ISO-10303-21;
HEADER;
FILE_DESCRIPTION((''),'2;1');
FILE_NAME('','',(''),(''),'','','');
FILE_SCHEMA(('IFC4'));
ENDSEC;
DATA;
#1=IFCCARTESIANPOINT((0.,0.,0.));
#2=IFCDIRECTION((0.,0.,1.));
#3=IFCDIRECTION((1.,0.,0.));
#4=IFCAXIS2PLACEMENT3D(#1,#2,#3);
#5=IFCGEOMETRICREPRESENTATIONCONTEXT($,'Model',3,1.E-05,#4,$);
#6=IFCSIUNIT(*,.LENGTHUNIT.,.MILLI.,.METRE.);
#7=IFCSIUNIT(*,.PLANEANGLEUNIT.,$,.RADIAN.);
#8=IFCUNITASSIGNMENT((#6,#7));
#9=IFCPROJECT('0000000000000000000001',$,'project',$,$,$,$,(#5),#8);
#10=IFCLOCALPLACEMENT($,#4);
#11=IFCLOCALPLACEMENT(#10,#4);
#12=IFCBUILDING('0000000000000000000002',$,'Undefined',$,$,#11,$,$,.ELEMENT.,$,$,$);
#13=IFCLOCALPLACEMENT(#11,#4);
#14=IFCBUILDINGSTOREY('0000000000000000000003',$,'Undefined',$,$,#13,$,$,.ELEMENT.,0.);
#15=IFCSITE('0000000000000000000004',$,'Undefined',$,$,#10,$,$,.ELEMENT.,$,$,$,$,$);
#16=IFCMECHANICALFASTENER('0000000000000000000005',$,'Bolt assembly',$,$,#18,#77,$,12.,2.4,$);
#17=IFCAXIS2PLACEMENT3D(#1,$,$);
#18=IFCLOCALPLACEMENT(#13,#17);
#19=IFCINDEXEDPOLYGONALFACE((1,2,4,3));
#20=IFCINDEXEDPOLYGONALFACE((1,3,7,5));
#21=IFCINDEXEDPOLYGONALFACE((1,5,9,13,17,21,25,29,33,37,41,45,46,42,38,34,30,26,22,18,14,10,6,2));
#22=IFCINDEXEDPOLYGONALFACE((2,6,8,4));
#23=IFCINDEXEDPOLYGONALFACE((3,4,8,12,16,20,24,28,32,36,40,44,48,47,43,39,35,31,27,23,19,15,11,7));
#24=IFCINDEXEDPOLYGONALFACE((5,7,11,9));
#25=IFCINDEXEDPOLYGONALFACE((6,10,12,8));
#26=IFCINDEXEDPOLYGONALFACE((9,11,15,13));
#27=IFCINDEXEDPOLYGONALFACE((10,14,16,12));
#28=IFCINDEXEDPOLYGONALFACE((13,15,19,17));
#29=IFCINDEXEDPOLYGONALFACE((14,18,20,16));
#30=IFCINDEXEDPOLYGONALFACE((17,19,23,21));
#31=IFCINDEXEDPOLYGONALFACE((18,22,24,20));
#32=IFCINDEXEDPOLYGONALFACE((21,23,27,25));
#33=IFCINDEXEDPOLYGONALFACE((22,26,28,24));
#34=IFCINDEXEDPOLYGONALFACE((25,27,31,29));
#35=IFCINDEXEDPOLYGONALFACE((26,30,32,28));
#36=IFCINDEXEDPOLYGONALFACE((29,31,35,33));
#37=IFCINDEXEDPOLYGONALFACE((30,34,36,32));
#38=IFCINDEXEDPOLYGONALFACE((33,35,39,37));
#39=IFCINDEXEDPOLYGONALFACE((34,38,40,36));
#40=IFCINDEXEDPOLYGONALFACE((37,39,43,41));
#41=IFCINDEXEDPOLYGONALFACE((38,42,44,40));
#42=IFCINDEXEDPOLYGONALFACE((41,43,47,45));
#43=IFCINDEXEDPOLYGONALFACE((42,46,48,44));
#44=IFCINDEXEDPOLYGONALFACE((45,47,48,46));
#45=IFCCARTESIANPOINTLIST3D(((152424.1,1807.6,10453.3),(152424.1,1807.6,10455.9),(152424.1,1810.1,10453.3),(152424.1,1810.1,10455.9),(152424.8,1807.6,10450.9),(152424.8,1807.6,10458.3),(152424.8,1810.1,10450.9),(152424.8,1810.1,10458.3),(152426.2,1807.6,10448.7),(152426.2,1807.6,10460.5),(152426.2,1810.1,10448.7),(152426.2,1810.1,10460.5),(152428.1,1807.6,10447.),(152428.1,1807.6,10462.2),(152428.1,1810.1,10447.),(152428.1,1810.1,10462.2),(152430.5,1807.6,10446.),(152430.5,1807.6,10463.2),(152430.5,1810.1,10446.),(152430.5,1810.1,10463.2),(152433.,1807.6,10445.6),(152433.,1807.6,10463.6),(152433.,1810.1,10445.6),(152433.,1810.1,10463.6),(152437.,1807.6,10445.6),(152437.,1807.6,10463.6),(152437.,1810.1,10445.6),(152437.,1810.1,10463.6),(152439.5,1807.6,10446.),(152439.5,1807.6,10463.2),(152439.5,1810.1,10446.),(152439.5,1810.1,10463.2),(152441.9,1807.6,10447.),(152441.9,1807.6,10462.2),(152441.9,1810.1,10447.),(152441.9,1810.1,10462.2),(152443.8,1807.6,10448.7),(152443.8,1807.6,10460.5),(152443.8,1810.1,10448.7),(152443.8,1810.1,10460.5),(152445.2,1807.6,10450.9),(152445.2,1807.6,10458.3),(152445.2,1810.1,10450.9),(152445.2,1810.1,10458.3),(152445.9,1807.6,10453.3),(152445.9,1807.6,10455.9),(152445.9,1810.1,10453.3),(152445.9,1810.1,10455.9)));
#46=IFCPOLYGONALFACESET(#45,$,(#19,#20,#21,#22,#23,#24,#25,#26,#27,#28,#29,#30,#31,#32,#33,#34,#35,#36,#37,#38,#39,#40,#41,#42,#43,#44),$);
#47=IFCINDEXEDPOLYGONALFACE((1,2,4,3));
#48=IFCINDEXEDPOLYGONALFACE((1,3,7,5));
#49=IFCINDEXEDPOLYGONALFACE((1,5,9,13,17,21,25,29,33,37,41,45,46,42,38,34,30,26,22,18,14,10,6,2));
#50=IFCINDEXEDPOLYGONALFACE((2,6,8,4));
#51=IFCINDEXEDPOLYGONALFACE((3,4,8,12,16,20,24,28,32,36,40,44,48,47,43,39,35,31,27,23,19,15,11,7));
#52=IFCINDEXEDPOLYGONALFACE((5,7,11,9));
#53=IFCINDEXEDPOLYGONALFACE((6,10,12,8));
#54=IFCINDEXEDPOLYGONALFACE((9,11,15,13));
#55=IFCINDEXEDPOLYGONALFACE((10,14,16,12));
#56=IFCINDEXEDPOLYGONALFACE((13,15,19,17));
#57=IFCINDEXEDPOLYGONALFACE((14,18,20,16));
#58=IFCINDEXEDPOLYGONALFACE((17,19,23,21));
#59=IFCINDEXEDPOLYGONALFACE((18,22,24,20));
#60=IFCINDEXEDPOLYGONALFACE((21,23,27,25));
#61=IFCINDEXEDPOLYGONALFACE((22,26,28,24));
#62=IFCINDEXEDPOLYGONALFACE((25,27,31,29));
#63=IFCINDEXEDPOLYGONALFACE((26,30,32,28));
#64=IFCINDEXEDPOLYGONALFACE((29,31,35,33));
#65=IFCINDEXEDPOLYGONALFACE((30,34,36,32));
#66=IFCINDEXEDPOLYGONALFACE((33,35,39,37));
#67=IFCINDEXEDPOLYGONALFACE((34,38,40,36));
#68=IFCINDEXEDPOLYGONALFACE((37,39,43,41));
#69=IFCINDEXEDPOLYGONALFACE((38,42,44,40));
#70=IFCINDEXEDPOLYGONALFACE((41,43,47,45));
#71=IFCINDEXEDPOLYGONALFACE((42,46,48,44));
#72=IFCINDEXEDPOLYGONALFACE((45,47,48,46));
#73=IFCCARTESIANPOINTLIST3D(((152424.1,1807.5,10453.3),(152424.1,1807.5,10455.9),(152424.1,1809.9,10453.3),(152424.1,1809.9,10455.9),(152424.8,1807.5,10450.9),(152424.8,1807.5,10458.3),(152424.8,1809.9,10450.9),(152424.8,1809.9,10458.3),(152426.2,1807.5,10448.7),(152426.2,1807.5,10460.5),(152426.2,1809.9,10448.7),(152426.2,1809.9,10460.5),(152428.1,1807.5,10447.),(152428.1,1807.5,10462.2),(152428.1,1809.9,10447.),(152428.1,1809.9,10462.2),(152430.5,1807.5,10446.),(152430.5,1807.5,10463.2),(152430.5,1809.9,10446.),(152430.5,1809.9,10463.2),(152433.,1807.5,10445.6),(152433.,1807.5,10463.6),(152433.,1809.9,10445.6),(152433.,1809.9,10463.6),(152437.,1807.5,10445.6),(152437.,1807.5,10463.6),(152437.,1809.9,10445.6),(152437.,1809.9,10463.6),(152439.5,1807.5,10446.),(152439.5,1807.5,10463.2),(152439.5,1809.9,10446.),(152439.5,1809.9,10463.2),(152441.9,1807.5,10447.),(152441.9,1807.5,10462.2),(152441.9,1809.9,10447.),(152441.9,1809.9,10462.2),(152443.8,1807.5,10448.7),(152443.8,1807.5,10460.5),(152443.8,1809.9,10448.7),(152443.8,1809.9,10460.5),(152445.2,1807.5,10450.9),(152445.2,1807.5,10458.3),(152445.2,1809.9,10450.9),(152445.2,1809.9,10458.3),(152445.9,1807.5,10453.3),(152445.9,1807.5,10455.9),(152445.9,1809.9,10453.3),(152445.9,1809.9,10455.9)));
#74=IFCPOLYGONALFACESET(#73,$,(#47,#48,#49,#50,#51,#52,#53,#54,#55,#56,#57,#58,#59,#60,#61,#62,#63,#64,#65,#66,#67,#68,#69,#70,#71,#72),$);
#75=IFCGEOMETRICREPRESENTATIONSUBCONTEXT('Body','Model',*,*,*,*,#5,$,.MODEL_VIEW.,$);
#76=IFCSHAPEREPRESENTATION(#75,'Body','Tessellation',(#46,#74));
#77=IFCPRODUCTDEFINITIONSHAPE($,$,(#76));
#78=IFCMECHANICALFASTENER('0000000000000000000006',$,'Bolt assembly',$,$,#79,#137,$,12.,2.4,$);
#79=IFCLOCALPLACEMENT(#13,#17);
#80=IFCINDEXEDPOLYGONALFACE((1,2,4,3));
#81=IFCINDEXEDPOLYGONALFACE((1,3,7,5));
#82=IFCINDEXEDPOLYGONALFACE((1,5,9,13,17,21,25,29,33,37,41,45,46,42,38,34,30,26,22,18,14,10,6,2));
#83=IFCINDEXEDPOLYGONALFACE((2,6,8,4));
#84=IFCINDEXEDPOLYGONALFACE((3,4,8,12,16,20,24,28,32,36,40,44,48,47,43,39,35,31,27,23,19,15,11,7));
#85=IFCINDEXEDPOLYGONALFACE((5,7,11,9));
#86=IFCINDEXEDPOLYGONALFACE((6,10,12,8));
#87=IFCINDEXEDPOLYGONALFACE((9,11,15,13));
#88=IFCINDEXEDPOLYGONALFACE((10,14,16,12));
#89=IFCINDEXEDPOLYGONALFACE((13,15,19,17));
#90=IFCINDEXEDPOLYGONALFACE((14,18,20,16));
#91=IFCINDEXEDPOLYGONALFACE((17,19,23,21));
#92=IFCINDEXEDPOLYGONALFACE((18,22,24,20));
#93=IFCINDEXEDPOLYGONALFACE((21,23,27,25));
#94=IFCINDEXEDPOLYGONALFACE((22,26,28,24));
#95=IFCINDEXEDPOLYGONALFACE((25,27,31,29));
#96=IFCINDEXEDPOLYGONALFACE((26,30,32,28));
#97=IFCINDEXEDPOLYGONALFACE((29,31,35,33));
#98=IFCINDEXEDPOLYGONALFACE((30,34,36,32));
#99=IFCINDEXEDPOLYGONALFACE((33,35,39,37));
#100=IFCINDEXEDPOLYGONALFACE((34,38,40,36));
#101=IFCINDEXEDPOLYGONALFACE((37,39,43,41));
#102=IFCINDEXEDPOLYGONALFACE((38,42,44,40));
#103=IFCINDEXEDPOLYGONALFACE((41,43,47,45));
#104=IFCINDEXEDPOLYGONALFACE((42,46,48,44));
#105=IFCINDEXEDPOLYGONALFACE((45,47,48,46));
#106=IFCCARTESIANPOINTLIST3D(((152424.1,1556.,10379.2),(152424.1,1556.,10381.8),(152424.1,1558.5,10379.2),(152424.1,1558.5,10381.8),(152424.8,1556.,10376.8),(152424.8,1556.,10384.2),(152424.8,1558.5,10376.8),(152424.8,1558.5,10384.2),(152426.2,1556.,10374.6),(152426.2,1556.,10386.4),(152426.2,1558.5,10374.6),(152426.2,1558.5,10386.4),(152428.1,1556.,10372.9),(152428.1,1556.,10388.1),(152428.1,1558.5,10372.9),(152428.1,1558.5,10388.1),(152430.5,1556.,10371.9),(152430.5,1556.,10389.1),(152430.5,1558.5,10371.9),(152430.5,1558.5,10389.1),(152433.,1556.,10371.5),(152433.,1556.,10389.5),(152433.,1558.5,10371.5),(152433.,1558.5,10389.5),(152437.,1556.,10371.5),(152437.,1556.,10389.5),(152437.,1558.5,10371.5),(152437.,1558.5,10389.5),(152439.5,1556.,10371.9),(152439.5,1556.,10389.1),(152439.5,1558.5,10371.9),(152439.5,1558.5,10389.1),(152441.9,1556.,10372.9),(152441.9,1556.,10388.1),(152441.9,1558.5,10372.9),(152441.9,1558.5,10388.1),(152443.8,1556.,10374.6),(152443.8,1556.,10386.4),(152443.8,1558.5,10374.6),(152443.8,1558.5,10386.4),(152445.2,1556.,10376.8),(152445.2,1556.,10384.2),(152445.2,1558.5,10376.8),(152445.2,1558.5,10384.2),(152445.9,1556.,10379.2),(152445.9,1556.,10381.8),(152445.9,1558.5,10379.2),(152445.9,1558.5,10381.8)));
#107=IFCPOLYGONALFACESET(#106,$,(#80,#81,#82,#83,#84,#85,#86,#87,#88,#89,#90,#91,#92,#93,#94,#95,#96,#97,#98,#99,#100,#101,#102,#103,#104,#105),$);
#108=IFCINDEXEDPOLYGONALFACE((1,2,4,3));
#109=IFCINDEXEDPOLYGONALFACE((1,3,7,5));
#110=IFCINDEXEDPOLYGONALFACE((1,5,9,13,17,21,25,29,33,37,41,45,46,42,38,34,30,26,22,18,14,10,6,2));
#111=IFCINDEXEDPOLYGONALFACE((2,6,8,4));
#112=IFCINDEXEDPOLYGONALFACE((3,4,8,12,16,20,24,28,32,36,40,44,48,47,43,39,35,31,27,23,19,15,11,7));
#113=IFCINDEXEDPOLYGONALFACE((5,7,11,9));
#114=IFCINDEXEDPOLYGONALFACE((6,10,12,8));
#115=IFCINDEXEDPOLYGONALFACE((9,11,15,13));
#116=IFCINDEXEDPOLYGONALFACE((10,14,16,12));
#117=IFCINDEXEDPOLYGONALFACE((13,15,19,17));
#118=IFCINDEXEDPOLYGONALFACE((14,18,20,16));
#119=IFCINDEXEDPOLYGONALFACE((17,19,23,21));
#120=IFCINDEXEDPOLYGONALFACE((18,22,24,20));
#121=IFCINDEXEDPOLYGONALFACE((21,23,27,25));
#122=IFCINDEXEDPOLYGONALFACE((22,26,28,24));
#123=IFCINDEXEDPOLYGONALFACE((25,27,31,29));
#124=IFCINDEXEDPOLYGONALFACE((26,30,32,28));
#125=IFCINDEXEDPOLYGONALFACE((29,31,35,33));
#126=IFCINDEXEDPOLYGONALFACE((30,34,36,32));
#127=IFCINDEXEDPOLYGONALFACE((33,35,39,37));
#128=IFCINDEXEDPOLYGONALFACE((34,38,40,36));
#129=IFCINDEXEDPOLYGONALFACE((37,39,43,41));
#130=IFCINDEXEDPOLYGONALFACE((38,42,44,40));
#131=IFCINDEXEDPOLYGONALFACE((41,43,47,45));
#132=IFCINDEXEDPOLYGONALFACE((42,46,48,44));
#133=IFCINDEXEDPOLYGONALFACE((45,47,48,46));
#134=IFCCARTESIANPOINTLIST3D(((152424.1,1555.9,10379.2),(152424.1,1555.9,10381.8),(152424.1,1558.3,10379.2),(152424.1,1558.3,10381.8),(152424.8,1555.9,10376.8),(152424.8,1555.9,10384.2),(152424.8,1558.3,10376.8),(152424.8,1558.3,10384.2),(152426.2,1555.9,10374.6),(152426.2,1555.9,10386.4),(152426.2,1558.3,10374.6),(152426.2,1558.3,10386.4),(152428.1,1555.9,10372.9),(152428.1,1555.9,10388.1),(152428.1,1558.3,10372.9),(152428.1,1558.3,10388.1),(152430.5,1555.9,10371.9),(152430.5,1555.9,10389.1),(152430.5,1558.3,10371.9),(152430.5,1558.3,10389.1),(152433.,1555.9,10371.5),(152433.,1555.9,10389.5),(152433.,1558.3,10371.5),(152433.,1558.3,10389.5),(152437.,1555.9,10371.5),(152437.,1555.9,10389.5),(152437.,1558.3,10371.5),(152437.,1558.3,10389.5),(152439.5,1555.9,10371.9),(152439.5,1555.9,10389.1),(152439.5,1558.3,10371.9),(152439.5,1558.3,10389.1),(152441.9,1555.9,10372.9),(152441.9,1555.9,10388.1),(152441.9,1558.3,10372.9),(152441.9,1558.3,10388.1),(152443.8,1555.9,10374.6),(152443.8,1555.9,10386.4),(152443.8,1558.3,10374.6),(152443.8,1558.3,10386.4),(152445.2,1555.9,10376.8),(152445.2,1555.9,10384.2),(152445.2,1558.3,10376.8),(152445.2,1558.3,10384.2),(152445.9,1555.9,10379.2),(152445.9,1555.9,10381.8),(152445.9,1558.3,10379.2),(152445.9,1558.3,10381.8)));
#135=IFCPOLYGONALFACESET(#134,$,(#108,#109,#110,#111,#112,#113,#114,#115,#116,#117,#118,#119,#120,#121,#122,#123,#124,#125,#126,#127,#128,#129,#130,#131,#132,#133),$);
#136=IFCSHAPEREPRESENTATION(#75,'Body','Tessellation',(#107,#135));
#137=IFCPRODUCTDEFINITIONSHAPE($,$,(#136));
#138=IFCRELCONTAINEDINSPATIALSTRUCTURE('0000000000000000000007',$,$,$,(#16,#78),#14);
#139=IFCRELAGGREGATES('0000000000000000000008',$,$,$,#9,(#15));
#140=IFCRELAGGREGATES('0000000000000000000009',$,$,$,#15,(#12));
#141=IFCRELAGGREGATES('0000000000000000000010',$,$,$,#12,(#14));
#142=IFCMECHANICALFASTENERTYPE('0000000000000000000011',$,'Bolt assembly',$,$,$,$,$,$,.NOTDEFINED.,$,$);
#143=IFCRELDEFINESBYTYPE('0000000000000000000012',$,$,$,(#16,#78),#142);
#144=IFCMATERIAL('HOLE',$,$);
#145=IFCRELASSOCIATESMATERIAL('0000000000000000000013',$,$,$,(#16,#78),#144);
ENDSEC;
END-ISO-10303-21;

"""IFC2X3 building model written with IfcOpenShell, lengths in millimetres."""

from ifc_helpers import new_model, entity, si_unit, frame, origin_with_axes, place, context, subcontext, project, spatial, source, transform, mapped, material, type_object, element, save


model = new_model("IFC2X3")

# Units and contexts
model_context = context("Model", 3, precision=1e-05, world=origin_with_axes())
body_context = subcontext(model_context, "Body", "Model", "MODEL_VIEW")
ifc_project = project(units=[si_unit("LENGTHUNIT", "METRE", prefix="MILLI"), si_unit("PLANEANGLEUNIT", "RADIAN")], contexts=[model_context])

# Site, building, storey
site_placement = place(None, origin_with_axes())
site = spatial("IfcSite", under=ifc_project, at=site_placement, Name="Undefined", CompositionType="ELEMENT")
building_placement = place(site_placement, origin_with_axes())
building = spatial("IfcBuilding", under=site, at=building_placement, Name="Undefined", CompositionType="ELEMENT")
storey_placement = place(building_placement, origin_with_axes())
storey = spatial("IfcBuildingStorey", under=building, at=storey_placement, Name="Undefined", CompositionType="ELEMENT", Elevation=0.0)

# Mechanical fasteners
ifc_material_1 = material(Name="HOLE")
mechanical_fastener_type = type_object("IfcMechanicalFastenerType", Name="Bolt assembly")
shared_circle_1 = entity("IfcCircle", entity("IfcAxis2Placement2D", entity("IfcCartesianPoint", [2.0, 0.0]), entity("IfcDirection", [0.0, 1.0])), 9.0)
shared_circle_2 = entity("IfcCircle", entity("IfcAxis2Placement2D", entity("IfcCartesianPoint", [-2.0, 0.0]), entity("IfcDirection", [0.0, -1.0])), 9.0)
shared_composite_curve = entity("IfcCompositeCurve", [entity("IfcCompositeCurveSegment", "CONTINUOUS", True, entity("IfcPolyline", [entity("IfcCartesianPoint", [-2.0, 9.0]), entity("IfcCartesianPoint", [2.0, 9.0])])), entity("IfcCompositeCurveSegment", "CONTINUOUS", True, entity("IfcTrimmedCurve", shared_circle_1, [entity("IfcParameterValue", 0.0)], [entity("IfcParameterValue", 3.141593)], False, "PARAMETER")), entity("IfcCompositeCurveSegment", "CONTINUOUS", True, entity("IfcPolyline", [entity("IfcCartesianPoint", [2.0, -9.0]), entity("IfcCartesianPoint", [-2.0, -9.0])])), entity("IfcCompositeCurveSegment", "DISCONTINUOUS", True, entity("IfcTrimmedCurve", shared_circle_2, [entity("IfcParameterValue", 0.0)], [entity("IfcParameterValue", 3.141593)], False, "PARAMETER"))], False)
shared_shape_1 = source(origin_with_axes(), body_context, "Body", "SweptSolid", [
    entity("IfcExtrudedAreaSolid", entity("IfcArbitraryClosedProfileDef", "AREA", None, shared_composite_curve), entity("IfcAxis2Placement3D", entity("IfcCartesianPoint", [0.0, -2.5, 0.0]), entity("IfcDirection", [0.0, 1.0, 0.0]), entity("IfcDirection", [1.0, 0.0, 0.0])), entity("IfcDirection", [0.0, 0.0, 1.0]), 2.5),
    entity("IfcExtrudedAreaSolid", entity("IfcArbitraryClosedProfileDef", "AREA", None, shared_composite_curve), entity("IfcAxis2Placement3D", entity("IfcCartesianPoint", [0.0, -2.3, 0.0]), entity("IfcDirection", [0.0, 1.0, 0.0]), entity("IfcDirection", [1.0, 0.0, 0.0])), entity("IfcDirection", [0.0, 0.0, 1.0]), 2.4),
])
mechanical_fastener_1_placement = place(storey_placement, frame((152435.0, 1807.6, 10454.6), z_axis=(0.0, 0.0, -1.0), x_axis=(1.0, 0.0, 0.0)))
element("IfcMechanicalFastener", 1, at=mechanical_fastener_1_placement, inside=storey, type_object=mechanical_fastener_type, material=ifc_material_1, Name="Bolt assembly", NominalDiameter=12.0, NominalLength=2.4, context=body_context, shape_type="MappedRepresentation", body=[
    mapped(shared_shape_1, transform((0.0, 0.0, 0.0))),
])
shared_shape_2 = source(origin_with_axes(), body_context, "Body", "SweptSolid", [
    entity("IfcExtrudedAreaSolid", entity("IfcArbitraryClosedProfileDef", "AREA", None, shared_composite_curve), entity("IfcAxis2Placement3D", entity("IfcCartesianPoint", [0.0, -2.5, 0.0]), entity("IfcDirection", [0.0, 1.0, 0.0]), entity("IfcDirection", [1.0, 0.0, 0.0])), entity("IfcDirection", [0.0, 0.0, 1.0]), 2.5),
    entity("IfcExtrudedAreaSolid", entity("IfcArbitraryClosedProfileDef", "AREA", None, shared_composite_curve), entity("IfcAxis2Placement3D", entity("IfcCartesianPoint", [0.0, -2.3, 0.0]), entity("IfcDirection", [0.0, 1.0, 0.0]), entity("IfcDirection", [1.0, 0.0, 0.0])), entity("IfcDirection", [0.0, 0.0, 1.0]), 2.4),
])
mechanical_fastener_2_placement = place(storey_placement, frame((152435.0, 1556.0, 10380.5), z_axis=(0.0, 0.0, -1.0), x_axis=(1.0, 0.0, 0.0)))
element("IfcMechanicalFastener", 2, at=mechanical_fastener_2_placement, inside=storey, type_object=mechanical_fastener_type, material=ifc_material_1, Name="Bolt assembly", NominalDiameter=12.0, NominalLength=2.4, context=body_context, shape_type="MappedRepresentation", body=[
    mapped(shared_shape_2, transform((0.0, 0.0, 0.0))),
])

save(model, "model.ifc")
